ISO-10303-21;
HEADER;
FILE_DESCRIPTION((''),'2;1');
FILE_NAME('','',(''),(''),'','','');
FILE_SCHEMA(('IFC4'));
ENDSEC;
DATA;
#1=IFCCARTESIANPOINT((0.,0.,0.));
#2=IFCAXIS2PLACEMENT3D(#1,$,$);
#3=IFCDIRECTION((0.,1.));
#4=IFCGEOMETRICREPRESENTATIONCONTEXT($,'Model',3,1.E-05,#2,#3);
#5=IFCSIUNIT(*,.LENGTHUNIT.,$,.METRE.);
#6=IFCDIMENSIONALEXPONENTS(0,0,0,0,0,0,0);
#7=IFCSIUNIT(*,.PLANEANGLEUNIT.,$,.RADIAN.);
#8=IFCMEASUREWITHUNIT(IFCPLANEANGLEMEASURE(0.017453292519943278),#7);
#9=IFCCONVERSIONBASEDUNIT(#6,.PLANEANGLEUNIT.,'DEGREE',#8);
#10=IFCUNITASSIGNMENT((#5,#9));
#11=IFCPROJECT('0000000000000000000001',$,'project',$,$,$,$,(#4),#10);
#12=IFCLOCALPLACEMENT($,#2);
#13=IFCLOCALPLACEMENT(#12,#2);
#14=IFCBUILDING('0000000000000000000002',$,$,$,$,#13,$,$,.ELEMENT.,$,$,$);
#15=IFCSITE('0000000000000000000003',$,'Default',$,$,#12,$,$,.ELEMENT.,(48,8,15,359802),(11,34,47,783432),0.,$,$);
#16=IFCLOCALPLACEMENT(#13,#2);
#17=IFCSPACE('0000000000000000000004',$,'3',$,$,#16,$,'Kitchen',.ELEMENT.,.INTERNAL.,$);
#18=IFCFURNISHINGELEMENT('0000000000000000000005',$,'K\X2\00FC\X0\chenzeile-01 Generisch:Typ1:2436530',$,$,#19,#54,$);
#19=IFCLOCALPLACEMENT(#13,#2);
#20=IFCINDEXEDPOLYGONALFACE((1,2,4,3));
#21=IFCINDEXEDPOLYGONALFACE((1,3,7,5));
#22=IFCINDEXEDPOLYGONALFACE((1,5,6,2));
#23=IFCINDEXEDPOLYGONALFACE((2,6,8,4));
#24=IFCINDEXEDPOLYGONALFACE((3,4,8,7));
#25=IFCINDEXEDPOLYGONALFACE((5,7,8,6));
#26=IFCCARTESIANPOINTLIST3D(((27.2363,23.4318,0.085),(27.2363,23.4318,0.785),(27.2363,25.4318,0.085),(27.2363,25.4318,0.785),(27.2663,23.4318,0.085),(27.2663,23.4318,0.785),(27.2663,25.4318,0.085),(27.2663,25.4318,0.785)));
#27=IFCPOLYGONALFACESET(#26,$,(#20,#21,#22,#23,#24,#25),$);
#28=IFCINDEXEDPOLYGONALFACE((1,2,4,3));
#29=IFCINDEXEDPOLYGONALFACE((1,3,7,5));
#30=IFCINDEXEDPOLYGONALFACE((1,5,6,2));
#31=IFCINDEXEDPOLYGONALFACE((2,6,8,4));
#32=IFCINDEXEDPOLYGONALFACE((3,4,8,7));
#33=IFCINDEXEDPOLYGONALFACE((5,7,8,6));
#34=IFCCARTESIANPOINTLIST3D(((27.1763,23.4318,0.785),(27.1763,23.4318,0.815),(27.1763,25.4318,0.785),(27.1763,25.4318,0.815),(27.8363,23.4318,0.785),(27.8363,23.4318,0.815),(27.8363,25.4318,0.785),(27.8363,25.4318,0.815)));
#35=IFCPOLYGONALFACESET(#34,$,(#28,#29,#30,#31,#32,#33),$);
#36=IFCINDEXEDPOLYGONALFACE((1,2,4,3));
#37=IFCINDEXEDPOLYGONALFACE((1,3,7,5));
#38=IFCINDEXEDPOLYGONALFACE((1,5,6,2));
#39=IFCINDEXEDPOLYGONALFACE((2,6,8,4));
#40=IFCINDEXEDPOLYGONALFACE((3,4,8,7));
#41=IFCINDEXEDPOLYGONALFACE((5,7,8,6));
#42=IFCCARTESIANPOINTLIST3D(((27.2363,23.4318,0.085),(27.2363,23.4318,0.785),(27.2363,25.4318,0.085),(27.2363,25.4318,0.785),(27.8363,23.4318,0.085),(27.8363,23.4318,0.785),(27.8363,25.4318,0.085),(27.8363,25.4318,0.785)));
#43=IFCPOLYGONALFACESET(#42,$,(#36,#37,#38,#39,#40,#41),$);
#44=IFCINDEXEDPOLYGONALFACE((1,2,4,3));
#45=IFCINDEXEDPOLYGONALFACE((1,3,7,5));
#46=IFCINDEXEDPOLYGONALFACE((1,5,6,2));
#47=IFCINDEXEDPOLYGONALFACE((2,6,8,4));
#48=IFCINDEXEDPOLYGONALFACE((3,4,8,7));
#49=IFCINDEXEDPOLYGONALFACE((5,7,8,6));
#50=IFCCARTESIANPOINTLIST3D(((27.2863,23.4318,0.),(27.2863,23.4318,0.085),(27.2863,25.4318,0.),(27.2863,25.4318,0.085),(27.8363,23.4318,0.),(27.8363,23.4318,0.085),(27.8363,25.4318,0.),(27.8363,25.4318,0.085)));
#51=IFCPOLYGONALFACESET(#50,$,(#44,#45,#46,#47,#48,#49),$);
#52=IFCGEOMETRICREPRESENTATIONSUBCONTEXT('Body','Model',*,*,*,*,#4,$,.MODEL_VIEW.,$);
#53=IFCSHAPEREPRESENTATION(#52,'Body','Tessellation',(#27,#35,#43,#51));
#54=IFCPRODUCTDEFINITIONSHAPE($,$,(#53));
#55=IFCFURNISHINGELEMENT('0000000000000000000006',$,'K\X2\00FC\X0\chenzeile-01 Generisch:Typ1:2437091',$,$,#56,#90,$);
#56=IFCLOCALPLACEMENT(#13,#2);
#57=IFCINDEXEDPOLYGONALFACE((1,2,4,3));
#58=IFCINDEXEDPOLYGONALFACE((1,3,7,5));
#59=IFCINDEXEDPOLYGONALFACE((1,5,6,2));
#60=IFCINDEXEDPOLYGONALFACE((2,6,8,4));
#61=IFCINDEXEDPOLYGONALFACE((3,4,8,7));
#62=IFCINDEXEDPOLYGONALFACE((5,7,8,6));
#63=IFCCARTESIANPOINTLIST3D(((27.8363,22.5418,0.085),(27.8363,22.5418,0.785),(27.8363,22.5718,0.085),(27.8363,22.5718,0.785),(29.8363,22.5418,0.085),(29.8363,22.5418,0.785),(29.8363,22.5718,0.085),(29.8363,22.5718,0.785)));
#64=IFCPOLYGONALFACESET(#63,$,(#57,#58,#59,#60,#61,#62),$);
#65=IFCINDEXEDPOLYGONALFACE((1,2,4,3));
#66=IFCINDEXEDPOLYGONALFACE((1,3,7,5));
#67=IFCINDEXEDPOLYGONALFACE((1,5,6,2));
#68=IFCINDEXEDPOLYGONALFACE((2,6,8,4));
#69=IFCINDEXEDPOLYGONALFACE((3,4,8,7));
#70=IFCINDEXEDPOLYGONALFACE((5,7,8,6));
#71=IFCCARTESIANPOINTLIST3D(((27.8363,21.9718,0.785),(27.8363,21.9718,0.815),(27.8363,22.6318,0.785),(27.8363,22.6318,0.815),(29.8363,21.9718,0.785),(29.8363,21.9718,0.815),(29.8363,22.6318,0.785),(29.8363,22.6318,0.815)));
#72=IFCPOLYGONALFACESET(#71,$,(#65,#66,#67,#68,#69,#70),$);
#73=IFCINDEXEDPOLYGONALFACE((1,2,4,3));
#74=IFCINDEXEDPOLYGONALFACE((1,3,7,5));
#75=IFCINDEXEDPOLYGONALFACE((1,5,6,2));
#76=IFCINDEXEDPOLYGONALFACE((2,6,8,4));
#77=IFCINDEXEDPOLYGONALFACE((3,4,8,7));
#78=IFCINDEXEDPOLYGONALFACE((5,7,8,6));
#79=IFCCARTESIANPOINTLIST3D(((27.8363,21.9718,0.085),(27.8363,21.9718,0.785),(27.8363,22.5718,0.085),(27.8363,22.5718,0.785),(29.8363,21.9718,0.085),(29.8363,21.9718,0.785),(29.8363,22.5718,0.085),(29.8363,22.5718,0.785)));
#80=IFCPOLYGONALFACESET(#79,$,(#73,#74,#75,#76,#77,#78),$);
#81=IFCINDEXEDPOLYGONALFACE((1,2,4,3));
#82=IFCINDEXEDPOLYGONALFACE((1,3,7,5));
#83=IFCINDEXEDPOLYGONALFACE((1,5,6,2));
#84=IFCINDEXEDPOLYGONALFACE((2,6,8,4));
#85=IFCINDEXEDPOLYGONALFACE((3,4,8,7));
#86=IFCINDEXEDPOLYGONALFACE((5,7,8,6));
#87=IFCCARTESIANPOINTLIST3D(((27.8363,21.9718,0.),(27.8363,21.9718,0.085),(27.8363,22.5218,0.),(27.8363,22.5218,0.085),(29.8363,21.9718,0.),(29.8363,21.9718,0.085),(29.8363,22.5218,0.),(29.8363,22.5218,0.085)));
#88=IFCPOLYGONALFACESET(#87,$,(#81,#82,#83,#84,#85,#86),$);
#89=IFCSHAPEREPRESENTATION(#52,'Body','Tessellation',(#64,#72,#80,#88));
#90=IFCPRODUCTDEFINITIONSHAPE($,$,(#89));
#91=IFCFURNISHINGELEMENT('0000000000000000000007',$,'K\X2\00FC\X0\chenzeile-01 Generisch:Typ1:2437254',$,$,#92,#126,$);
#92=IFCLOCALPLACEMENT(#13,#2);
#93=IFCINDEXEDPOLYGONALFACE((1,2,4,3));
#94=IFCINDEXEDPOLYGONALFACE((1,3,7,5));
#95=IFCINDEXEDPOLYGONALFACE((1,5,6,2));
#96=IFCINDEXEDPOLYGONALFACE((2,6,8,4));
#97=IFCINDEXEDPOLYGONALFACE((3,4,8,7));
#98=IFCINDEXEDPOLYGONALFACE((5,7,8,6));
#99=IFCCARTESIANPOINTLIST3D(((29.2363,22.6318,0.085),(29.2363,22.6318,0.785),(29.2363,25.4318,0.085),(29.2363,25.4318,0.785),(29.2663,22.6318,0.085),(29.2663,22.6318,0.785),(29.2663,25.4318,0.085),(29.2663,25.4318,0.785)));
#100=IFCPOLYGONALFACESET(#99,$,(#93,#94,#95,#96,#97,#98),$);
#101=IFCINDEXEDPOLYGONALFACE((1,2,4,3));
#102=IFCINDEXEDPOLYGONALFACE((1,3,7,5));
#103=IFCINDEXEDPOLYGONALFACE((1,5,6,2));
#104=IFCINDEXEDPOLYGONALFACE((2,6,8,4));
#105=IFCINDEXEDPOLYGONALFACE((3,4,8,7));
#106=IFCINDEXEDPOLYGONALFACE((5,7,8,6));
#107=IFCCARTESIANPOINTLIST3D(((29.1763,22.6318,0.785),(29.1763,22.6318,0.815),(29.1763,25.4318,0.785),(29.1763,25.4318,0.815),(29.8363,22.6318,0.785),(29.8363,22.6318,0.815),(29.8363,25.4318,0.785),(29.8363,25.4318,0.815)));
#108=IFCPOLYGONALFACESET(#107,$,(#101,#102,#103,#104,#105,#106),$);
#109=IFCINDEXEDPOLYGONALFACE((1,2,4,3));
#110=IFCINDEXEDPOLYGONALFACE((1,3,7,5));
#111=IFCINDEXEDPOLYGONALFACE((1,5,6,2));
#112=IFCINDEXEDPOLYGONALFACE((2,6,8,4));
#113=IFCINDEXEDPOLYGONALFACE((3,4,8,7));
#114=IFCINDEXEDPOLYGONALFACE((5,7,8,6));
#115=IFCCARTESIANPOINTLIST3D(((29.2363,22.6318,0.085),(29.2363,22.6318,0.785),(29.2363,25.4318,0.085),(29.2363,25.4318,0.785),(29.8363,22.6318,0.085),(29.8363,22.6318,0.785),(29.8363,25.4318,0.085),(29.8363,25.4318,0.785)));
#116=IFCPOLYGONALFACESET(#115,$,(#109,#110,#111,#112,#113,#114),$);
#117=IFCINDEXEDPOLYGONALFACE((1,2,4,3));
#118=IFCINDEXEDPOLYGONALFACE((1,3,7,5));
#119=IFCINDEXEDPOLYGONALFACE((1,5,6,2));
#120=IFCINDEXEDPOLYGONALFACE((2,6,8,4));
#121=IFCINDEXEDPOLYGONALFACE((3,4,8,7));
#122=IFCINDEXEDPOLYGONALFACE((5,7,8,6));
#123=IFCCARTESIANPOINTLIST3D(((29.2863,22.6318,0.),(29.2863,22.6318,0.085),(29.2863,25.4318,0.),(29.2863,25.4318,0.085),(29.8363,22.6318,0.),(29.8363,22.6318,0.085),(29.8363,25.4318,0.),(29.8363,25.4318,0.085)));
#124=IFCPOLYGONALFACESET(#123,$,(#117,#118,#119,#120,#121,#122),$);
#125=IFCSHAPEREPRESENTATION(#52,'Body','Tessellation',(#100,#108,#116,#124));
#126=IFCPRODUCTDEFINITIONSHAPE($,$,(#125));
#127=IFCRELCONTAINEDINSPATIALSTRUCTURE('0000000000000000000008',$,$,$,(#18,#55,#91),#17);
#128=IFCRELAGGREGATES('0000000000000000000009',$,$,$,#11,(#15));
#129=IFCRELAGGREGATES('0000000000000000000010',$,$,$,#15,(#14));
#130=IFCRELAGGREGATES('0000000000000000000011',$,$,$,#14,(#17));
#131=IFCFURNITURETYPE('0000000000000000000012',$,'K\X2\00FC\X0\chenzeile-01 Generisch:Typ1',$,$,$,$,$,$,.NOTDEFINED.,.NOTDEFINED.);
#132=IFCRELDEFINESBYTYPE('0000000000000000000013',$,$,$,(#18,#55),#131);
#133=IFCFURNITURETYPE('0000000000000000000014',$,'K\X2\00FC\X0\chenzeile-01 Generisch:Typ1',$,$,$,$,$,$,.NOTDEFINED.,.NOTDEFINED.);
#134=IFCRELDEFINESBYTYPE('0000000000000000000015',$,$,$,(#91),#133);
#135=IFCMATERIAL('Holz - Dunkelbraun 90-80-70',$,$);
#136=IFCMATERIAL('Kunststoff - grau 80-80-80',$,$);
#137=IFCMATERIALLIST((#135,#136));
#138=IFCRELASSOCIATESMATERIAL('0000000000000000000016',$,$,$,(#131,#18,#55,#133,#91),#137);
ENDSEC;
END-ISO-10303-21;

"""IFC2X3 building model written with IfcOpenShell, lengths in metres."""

from ifc_helpers import new_model, entity, si_unit, converted_unit, direction, frame, frame_2d, origin, origin_2d_with_axis, place, context, subcontext, project, spatial, rectangle, extrude, source, transform, mapped, material, material_list, type_object, type_shapes, element, save


model = new_model("IFC2X3")

# Units and contexts
model_context = context("Model", 3, precision=1e-05, world=origin(), true_north=direction((0.0, 1.0)))
body_context = subcontext(model_context, "Body", "Model", "MODEL_VIEW")
ifc_project = project(units=[si_unit("LENGTHUNIT", "METRE"), converted_unit("PLANEANGLEUNIT", "DEGREE", entity("IfcPlaneAngleMeasure", 0.017453292519943278), si_unit("PLANEANGLEUNIT", "RADIAN"), dimensions=[0, 0, 0, 0, 0, 0, 0])], contexts=[model_context])

# Site, building, space
site_placement = place(None, origin())
site = spatial("IfcSite", under=ifc_project, at=site_placement, Name="Default", CompositionType="ELEMENT", RefLatitude=(48, 8, 15, 359802), RefLongitude=(11, 34, 47, 783432), RefElevation=0.0)
building_placement = place(site_placement, origin())
building = spatial("IfcBuilding", under=site, at=building_placement, CompositionType="ELEMENT")
space_placement = place(building_placement, origin())
space = spatial("IfcSpace", under=building, at=space_placement, Name="3", LongName="Kitchen", CompositionType="ELEMENT", InteriorOrExteriorSpace="INTERNAL")

# Furnishing elements
ifc_material_1 = material(Name="Holz - Dunkelbraun 90-80-70")
ifc_material_2 = material(Name="Kunststoff - grau 80-80-80")
ifc_material_list = material_list([ifc_material_1, ifc_material_2])
furniture_type_1 = type_object("IfcFurnitureType", Name="Küchenzeile-01 Generisch:Typ1", AssemblyPlace="NOTDEFINED", material=ifc_material_list)
shared_shape_1 = source(origin(), body_context, "Body", "SweptSolid", [
    extrude(rectangle(XDim=2.0, YDim=0.03, at=origin_2d_with_axis()), frame((-0.72, -0.285, 0.085)), (0.0, 0.0, 1.0), 0.7),
    extrude(rectangle(XDim=2.0, YDim=0.66, at=origin_2d_with_axis()), frame((-0.72, -0.03, 0.785)), (0.0, 0.0, 1.0), 0.03),
    extrude(rectangle(XDim=2.0, YDim=0.6, at=origin_2d_with_axis()), frame((-0.72, 0.0, 0.085)), (0.0, 0.0, 1.0), 0.7),
    extrude(rectangle(XDim=2.0, YDim=0.55, at=origin_2d_with_axis()), frame((-0.72, 0.025, 0.0)), (0.0, 0.0, 1.0), 0.085),
])
type_shapes(furniture_type_1, [shared_shape_1])
for number, where, z_axis, x_axis, name in (
    (1, (27.5363, 23.7118, 0.0), (0.0, 0.0, 1.0), (0.0, -1.0, 0.0), "Küchenzeile-01 Generisch:Typ1:2436530"),
    (2, (28.1163, 22.2718, 0.0), (0.0, 0.0, 1.0), (-1.0, 0.0, 0.0), "Küchenzeile-01 Generisch:Typ1:2437091"),
):
    element("IfcFurnishingElement", number, at=place(space_placement, frame(where, z_axis=z_axis, x_axis=x_axis)), inside=space, type_object=furniture_type_1, material=ifc_material_list, Name=name, context=body_context, shape_type="MappedRepresentation", body=[
        mapped(shared_shape_1, transform((0.0, 0.0, 0.0), scale=1.0)),
    ])
furniture_type_2 = type_object("IfcFurnitureType", Name="Küchenzeile-01 Generisch:Typ1", AssemblyPlace="NOTDEFINED", material=ifc_material_list)
shared_shape_2 = source(origin(), body_context, "Body", "SweptSolid", [
    extrude(rectangle(XDim=2.8, YDim=0.03, at=origin_2d_with_axis()), frame((-1.12, -0.285, 0.085)), (0.0, 0.0, 1.0), 0.7),
    extrude(rectangle(XDim=2.8, YDim=0.66, at=frame_2d((0.0, 0.0), x_axis=(1.0, 0.0))), frame((-1.12, -0.03, 0.785)), (0.0, 0.0, 1.0), 0.03),
    extrude(rectangle(XDim=2.8, YDim=0.6, at=origin_2d_with_axis()), frame((-1.12, 0.0, 0.085)), (0.0, 0.0, 1.0), 0.7),
    extrude(rectangle(XDim=2.8, YDim=0.55, at=origin_2d_with_axis()), frame((-1.12, 0.025, 0.0)), (0.0, 0.0, 1.0), 0.085),
])
type_shapes(furniture_type_2, [shared_shape_2])
furnishing_placement = place(space_placement, frame((29.5363, 22.9118, 0.0), z_axis=(0.0, 0.0, 1.0), x_axis=(0.0, -1.0, 0.0)))
element("IfcFurnishingElement", 3, at=furnishing_placement, inside=space, type_object=furniture_type_2, material=ifc_material_list, Name="Küchenzeile-01 Generisch:Typ1:2437254", context=body_context, shape_type="MappedRepresentation", body=[
    mapped(shared_shape_2, transform((0.0, 0.0, 0.0), scale=1.0)),
])

save(model, "model.ifc")
